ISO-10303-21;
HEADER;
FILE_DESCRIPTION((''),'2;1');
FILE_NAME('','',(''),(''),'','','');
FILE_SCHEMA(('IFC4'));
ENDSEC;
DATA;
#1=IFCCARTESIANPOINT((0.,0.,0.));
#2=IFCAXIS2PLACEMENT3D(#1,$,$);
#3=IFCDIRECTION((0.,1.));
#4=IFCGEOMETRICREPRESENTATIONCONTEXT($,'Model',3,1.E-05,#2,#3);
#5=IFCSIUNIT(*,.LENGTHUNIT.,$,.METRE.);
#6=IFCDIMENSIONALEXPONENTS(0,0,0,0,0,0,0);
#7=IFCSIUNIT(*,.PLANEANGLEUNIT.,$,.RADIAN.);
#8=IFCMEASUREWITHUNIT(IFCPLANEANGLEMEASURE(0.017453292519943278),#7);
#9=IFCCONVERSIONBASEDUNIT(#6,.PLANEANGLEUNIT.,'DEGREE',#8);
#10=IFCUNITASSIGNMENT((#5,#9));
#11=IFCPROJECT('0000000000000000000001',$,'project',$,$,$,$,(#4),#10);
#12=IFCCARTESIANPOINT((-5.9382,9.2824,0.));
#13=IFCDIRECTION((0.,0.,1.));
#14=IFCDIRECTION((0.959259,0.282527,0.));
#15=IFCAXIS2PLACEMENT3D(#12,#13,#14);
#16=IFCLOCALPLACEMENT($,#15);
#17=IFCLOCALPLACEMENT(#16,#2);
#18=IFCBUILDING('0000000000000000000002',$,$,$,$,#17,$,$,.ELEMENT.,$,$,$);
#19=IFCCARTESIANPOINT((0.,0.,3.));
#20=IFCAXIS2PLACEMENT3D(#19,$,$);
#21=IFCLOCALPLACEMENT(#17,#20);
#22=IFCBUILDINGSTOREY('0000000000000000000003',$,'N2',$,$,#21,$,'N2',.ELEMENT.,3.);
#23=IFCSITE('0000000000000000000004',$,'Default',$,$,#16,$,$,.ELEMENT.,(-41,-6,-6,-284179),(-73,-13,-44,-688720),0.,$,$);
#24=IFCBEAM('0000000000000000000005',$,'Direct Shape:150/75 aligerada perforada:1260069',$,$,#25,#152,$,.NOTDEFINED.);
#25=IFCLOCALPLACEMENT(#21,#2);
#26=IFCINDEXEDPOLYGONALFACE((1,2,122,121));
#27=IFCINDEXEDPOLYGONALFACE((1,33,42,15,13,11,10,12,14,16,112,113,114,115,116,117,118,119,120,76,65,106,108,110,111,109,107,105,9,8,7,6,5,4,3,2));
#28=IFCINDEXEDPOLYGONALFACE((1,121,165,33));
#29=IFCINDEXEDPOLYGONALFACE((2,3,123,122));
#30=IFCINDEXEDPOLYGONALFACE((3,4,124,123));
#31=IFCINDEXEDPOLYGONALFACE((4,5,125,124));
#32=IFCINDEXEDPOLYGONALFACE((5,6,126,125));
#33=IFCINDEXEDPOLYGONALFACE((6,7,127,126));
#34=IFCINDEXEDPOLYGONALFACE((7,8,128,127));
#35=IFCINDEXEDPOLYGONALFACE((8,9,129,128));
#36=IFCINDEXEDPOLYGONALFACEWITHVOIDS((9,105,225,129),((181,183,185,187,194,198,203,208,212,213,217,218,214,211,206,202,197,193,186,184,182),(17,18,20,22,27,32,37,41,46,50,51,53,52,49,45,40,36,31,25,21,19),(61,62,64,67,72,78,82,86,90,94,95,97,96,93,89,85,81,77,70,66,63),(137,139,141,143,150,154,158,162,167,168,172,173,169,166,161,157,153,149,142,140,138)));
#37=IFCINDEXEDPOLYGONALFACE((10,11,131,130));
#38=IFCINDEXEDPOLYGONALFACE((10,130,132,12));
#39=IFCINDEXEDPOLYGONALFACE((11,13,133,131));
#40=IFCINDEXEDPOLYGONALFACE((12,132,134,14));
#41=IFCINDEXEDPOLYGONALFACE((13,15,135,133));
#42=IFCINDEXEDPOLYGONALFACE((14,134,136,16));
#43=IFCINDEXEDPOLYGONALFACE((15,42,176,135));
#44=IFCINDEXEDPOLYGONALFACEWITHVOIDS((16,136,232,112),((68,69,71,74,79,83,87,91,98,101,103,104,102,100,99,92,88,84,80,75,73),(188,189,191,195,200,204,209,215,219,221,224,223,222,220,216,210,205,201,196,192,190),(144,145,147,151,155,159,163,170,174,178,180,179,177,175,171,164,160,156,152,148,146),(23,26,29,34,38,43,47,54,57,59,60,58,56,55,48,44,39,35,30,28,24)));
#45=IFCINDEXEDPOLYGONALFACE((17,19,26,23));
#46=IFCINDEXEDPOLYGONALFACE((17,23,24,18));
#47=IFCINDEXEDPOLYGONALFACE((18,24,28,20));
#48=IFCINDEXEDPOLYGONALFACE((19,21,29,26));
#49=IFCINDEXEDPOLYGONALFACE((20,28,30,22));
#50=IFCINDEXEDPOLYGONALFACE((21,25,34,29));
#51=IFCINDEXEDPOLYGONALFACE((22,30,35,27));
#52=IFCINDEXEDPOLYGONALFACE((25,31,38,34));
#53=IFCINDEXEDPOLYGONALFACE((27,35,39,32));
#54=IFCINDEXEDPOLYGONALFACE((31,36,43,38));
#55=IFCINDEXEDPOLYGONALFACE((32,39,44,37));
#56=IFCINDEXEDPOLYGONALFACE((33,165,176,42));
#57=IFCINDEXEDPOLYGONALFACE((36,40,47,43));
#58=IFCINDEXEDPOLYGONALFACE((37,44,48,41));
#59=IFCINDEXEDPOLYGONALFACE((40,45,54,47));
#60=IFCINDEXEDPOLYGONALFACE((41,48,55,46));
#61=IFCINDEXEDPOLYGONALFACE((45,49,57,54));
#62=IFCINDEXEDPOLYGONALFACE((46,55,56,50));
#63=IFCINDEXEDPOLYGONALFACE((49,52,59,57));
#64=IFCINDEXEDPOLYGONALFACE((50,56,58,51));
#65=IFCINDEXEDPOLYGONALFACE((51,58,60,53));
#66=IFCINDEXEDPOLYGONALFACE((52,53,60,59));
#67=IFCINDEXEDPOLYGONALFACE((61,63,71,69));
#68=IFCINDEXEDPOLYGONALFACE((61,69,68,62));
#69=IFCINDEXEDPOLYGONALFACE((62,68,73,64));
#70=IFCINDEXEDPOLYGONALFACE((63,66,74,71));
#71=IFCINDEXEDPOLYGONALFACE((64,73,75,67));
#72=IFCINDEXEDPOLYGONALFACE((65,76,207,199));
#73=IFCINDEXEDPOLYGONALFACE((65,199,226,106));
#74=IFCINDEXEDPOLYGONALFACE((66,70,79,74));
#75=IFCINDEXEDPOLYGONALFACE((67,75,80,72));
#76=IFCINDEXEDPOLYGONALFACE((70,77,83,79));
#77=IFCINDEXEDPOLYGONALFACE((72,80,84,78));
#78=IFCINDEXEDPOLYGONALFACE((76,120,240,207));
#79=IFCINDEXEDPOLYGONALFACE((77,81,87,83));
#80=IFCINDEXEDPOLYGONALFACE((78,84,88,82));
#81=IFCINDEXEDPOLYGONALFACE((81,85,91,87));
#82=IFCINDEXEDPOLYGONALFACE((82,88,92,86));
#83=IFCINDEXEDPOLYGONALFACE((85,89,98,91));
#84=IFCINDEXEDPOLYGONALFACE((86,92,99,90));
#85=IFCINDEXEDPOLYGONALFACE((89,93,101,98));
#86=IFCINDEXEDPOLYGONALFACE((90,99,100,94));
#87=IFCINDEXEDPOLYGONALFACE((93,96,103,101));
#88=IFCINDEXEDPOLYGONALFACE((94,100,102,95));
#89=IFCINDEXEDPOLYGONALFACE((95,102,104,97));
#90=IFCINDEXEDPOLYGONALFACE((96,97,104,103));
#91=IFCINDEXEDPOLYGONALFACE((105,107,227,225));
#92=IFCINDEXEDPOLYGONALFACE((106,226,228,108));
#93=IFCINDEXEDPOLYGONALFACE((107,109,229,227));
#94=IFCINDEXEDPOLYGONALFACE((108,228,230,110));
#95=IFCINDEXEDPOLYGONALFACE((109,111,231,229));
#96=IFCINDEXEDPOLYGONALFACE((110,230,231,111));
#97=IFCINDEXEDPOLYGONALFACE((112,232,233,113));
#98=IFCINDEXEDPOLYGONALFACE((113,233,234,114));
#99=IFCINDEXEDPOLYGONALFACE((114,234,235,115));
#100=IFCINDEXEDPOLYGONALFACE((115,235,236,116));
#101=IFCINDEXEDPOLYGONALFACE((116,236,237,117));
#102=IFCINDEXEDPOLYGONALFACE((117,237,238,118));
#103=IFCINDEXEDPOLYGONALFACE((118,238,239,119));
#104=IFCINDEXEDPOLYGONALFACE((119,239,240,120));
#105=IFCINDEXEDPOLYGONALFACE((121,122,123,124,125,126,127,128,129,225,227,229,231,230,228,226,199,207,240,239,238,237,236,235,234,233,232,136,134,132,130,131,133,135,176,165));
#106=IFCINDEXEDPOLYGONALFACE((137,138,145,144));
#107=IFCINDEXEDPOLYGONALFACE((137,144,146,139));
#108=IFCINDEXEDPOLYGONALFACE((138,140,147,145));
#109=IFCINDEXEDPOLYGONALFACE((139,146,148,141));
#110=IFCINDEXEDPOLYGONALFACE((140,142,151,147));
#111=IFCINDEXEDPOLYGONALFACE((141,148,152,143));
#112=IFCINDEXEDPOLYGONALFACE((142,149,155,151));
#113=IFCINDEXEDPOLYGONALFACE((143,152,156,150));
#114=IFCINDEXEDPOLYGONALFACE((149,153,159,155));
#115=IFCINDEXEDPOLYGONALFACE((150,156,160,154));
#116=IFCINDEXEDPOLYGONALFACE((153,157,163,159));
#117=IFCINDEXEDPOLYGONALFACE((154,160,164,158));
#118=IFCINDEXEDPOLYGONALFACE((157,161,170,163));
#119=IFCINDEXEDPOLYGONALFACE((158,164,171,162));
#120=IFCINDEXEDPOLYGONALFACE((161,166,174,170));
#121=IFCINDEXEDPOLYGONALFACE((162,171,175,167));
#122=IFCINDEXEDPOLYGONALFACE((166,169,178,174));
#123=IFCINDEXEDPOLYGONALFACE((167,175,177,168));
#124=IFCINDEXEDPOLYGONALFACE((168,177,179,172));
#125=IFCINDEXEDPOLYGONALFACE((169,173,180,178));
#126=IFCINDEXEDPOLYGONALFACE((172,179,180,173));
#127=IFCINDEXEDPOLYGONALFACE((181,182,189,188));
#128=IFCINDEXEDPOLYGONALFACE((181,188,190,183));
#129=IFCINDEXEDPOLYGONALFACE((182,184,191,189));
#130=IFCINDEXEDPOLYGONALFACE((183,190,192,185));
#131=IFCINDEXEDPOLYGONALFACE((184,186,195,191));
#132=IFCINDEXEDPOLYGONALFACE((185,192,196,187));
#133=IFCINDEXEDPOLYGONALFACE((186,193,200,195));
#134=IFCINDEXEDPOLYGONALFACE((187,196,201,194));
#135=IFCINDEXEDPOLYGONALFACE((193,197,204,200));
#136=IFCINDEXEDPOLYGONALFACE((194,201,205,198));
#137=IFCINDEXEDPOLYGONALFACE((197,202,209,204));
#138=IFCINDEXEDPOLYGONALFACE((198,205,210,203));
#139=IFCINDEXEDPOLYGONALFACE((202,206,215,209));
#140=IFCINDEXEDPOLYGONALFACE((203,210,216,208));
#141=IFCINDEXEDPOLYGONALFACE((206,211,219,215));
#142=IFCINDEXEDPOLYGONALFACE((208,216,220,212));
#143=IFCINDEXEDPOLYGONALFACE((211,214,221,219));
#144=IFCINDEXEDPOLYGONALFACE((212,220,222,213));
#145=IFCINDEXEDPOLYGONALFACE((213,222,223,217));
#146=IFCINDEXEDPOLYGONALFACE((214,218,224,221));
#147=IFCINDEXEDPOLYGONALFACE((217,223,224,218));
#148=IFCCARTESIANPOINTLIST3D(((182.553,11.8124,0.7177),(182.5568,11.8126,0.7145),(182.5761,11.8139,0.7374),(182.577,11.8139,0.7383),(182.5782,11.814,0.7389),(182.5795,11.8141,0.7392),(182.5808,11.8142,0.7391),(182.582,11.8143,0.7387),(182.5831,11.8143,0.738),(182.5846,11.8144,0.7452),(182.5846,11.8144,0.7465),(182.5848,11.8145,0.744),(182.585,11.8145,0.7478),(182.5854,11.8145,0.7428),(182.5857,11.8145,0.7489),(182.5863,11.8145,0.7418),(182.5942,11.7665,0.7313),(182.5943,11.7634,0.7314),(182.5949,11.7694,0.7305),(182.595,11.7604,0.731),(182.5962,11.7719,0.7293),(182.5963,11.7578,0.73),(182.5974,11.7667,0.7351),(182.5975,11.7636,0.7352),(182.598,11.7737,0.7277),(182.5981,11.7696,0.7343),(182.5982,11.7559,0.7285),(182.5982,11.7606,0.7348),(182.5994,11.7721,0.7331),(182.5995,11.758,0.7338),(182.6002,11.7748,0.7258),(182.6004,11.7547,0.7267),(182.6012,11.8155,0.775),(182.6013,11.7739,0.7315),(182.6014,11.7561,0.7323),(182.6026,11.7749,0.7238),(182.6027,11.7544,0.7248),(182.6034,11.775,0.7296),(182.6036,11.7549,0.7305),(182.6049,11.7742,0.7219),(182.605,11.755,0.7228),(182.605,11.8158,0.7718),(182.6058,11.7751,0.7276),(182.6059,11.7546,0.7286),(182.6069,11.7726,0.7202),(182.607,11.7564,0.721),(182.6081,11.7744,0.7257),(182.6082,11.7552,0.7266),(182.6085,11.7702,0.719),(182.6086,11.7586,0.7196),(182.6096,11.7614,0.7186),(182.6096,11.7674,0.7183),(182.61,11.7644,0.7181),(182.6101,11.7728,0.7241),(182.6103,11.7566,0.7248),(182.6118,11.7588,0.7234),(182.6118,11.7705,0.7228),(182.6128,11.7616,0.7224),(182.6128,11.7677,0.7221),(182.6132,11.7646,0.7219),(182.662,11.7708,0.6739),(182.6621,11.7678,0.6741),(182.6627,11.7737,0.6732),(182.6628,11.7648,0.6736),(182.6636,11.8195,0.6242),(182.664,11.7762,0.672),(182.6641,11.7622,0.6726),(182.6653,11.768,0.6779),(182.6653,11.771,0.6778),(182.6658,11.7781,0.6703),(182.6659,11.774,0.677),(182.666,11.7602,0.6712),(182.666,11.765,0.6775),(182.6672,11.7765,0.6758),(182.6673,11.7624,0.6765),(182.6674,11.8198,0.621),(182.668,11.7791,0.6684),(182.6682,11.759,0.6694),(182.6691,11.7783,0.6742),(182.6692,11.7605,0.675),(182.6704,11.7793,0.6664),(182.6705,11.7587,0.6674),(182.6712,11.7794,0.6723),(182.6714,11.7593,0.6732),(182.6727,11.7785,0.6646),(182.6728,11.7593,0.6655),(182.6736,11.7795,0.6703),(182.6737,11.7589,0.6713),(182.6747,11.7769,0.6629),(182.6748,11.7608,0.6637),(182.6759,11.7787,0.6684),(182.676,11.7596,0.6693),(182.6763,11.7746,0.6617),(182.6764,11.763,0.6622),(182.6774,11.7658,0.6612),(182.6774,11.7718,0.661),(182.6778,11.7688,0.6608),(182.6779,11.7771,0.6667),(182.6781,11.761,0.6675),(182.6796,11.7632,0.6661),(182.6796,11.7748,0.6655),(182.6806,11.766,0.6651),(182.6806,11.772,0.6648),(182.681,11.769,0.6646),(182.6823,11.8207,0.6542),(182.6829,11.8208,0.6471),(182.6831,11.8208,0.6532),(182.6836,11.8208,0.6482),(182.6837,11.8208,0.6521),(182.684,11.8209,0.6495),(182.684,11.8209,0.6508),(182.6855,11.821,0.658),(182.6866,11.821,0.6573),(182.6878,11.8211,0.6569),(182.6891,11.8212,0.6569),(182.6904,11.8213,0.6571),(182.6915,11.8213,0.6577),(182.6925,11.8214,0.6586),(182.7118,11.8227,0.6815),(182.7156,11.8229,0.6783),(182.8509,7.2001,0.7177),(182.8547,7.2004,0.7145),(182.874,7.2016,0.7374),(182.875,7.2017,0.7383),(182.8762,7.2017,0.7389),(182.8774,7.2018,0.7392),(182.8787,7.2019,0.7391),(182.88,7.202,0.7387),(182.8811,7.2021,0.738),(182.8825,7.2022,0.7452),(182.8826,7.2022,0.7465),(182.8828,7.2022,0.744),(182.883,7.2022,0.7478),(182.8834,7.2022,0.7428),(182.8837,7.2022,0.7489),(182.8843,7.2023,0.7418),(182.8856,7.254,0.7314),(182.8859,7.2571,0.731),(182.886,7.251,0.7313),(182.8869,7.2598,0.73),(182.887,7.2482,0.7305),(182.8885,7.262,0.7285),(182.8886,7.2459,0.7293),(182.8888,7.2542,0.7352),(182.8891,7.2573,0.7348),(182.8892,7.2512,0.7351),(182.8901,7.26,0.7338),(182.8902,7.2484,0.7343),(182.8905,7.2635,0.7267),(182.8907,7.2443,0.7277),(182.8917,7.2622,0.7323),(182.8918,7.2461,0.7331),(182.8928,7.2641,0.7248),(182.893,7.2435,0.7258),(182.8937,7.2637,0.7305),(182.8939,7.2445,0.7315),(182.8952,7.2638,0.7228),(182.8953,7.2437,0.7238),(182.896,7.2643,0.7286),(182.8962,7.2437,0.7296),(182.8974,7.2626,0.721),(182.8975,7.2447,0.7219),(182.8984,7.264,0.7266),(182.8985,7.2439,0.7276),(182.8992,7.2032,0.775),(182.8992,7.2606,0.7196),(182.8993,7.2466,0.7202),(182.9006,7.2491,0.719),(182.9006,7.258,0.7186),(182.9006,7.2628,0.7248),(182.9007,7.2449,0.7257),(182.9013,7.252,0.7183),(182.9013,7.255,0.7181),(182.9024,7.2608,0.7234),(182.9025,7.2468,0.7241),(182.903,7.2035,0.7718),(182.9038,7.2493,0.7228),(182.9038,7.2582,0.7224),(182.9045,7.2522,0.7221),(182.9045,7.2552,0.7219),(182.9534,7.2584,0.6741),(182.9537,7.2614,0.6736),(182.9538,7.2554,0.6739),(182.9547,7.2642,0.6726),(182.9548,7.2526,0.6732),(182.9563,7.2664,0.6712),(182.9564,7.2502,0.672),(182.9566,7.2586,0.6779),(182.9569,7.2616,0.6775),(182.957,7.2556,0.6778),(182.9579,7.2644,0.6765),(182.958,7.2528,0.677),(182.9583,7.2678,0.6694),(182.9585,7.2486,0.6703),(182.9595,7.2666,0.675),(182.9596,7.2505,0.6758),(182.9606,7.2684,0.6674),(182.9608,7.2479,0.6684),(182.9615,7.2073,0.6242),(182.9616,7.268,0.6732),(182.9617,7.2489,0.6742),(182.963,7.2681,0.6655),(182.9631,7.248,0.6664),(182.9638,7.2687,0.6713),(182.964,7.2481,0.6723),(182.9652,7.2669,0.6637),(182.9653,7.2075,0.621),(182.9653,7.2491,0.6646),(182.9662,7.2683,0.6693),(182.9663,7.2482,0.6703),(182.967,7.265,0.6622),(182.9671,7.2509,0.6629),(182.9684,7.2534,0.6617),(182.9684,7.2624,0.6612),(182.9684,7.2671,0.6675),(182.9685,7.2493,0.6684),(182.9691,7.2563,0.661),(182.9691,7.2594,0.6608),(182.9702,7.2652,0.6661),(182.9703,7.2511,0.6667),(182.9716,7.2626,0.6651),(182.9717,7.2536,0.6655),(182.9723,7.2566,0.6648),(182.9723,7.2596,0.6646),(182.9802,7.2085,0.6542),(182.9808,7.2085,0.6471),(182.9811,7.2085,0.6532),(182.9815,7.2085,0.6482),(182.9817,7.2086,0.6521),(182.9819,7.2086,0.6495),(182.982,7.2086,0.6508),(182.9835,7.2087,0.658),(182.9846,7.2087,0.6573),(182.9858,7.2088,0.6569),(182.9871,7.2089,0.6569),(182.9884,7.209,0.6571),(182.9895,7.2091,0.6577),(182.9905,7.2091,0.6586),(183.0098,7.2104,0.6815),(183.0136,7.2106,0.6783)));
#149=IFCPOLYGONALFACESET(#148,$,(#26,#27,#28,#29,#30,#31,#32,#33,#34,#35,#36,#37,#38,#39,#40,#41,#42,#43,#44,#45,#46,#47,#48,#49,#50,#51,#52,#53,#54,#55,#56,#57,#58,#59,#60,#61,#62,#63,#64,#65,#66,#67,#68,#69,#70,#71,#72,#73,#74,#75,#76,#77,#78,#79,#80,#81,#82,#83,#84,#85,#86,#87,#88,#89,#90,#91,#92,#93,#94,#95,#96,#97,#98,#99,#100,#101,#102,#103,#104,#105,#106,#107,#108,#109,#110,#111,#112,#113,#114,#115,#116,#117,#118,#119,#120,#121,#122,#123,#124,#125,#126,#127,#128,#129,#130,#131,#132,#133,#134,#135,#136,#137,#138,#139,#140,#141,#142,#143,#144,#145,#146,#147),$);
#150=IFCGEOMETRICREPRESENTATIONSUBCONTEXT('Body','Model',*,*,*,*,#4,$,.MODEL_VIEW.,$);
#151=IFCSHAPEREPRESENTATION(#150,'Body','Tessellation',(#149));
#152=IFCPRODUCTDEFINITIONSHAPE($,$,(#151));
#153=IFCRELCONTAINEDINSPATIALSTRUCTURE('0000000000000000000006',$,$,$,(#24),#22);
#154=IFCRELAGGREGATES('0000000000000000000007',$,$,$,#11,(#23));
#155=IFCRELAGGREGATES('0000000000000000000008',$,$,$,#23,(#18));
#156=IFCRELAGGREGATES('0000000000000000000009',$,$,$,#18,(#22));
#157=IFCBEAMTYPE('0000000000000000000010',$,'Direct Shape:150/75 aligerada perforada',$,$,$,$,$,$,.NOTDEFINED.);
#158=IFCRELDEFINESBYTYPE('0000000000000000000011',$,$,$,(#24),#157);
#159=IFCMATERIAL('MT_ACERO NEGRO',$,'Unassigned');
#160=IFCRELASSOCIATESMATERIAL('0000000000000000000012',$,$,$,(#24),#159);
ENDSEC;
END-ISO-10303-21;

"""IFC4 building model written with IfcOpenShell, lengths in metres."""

from ifc_helpers import new_model, entity, si_unit, converted_unit, direction, frame, frame_2d, origin, place, context, subcontext, project, spatial, circle, i_section, extrude, material, type_object, element, save


model = new_model("IFC4")

# Units and contexts
model_context = context("Model", 3, precision=1e-05, world=origin(), true_north=direction((0.0, 1.0)))
body_context = subcontext(model_context, "Body", "Model", "MODEL_VIEW")
ifc_project = project(units=[si_unit("LENGTHUNIT", "METRE"), converted_unit("PLANEANGLEUNIT", "DEGREE", entity("IfcPlaneAngleMeasure", 0.017453292519943278), si_unit("PLANEANGLEUNIT", "RADIAN"), dimensions=[0, 0, 0, 0, 0, 0, 0])], contexts=[model_context])

# Site, building, storey
site_placement = place(None, frame((-5.9382, 9.2824, 0.0), z_axis=(0.0, 0.0, 1.0), x_axis=(0.959259, 0.282527, 0.0)))
site = spatial("IfcSite", under=ifc_project, at=site_placement, Name="Default", CompositionType="ELEMENT", RefLatitude=(-41, -6, -6, -284179), RefLongitude=(-73, -13, -44, -688720), RefElevation=0.0)
building_placement = place(site_placement, origin())
building = spatial("IfcBuilding", under=site, at=building_placement, CompositionType="ELEMENT")
storey_placement = place(building_placement, frame((0.0, 0.0, 3.0)))
storey = spatial("IfcBuildingStorey", under=building, at=storey_placement, Name="N2", LongName="N2", CompositionType="ELEMENT", Elevation=3.0)

# Beam, openings
ifc_material = material(Name="MT_ACERO NEGRO", Category="Unassigned")
beam_type_1 = type_object("IfcBeamType", Name="Direct Shape:150/75 aligerada perforada", PredefinedType="NOTDEFINED")
beam_1_placement = place(storey_placement, origin())
beam_1 = element("IfcBeam", 1, at=beam_1_placement, inside=storey, type_object=beam_type_1, material=ifc_material, Name="Direct Shape:150/75 aligerada perforada:1260069", PredefinedType="NOTDEFINED", context=body_context, shape_type="SweptSolid", body=[
    extrude(i_section(OverallWidth=0.075, OverallDepth=0.15, WebThickness=0.005, FlangeThickness=0.005, FilletRadius=0.005, at=frame_2d((0.0, 0.0), x_axis=(0.0, 1.0))), frame((182.9323, 7.2054, 0.698), z_axis=(-0.064471, 0.99792, 0.0), x_axis=(-0.762769, -0.049279, 0.644791)), (0.0, 0.0, 1.0), 4.6219),
])
opening_1_placement = place(storey_placement, origin())
element("IfcOpeningElement", 2, at=opening_1_placement, cuts=beam_1, PredefinedType="OPENING", context=body_context, shape_type="SweptSolid", body=[
    extrude(circle(Radius=0.0103, at=frame_2d((0.0, 0.0), x_axis=(1.0, 0.0))), frame((182.9613, 7.2581, 0.6674), z_axis=(0.643449, 0.041571, 0.764359), x_axis=(-0.064468, 0.99792, -0.000003)), (0.0, 0.0, 1.0), 0.005),
])
opening_2_placement = place(storey_placement, origin())
element("IfcOpeningElement", 3, at=opening_2_placement, cuts=beam_1, PredefinedType="OPENING", context=body_context, shape_type="SweptSolid", body=[
    extrude(circle(Radius=0.0103, at=frame_2d((0.0, 0.0), x_axis=(1.0, 0.0))), frame((182.8935, 7.2538, 0.7248), z_axis=(0.643449, 0.041571, 0.764359), x_axis=(-0.064468, 0.99792, -0.000003)), (0.0, 0.0, 1.0), 0.005),
])
opening_3_placement = place(storey_placement, origin())
element("IfcOpeningElement", 4, at=opening_3_placement, cuts=beam_1, PredefinedType="OPENING", context=body_context, shape_type="SweptSolid", body=[
    extrude(circle(Radius=0.0103, at=frame_2d((0.0, 0.0), x_axis=(1.0, 0.0))), frame((182.6021, 11.7647, 0.7248), z_axis=(0.643449, 0.041571, 0.764359), x_axis=(0.064475, -0.997919, -0.000003)), (0.0, 0.0, 1.0), 0.005),
])
opening_4_placement = place(storey_placement, origin())
element("IfcOpeningElement", 5, at=opening_4_placement, cuts=beam_1, PredefinedType="OPENING", context=body_context, shape_type="SweptSolid", body=[
    extrude(circle(Radius=0.0103, at=frame_2d((0.0, 0.0), x_axis=(1.0, 0.0))), frame((182.6699, 11.769, 0.6674), z_axis=(0.643449, 0.041571, 0.764359), x_axis=(0.064475, -0.997919, -0.000003)), (0.0, 0.0, 1.0), 0.005),
])

save(model, "model.ifc")
